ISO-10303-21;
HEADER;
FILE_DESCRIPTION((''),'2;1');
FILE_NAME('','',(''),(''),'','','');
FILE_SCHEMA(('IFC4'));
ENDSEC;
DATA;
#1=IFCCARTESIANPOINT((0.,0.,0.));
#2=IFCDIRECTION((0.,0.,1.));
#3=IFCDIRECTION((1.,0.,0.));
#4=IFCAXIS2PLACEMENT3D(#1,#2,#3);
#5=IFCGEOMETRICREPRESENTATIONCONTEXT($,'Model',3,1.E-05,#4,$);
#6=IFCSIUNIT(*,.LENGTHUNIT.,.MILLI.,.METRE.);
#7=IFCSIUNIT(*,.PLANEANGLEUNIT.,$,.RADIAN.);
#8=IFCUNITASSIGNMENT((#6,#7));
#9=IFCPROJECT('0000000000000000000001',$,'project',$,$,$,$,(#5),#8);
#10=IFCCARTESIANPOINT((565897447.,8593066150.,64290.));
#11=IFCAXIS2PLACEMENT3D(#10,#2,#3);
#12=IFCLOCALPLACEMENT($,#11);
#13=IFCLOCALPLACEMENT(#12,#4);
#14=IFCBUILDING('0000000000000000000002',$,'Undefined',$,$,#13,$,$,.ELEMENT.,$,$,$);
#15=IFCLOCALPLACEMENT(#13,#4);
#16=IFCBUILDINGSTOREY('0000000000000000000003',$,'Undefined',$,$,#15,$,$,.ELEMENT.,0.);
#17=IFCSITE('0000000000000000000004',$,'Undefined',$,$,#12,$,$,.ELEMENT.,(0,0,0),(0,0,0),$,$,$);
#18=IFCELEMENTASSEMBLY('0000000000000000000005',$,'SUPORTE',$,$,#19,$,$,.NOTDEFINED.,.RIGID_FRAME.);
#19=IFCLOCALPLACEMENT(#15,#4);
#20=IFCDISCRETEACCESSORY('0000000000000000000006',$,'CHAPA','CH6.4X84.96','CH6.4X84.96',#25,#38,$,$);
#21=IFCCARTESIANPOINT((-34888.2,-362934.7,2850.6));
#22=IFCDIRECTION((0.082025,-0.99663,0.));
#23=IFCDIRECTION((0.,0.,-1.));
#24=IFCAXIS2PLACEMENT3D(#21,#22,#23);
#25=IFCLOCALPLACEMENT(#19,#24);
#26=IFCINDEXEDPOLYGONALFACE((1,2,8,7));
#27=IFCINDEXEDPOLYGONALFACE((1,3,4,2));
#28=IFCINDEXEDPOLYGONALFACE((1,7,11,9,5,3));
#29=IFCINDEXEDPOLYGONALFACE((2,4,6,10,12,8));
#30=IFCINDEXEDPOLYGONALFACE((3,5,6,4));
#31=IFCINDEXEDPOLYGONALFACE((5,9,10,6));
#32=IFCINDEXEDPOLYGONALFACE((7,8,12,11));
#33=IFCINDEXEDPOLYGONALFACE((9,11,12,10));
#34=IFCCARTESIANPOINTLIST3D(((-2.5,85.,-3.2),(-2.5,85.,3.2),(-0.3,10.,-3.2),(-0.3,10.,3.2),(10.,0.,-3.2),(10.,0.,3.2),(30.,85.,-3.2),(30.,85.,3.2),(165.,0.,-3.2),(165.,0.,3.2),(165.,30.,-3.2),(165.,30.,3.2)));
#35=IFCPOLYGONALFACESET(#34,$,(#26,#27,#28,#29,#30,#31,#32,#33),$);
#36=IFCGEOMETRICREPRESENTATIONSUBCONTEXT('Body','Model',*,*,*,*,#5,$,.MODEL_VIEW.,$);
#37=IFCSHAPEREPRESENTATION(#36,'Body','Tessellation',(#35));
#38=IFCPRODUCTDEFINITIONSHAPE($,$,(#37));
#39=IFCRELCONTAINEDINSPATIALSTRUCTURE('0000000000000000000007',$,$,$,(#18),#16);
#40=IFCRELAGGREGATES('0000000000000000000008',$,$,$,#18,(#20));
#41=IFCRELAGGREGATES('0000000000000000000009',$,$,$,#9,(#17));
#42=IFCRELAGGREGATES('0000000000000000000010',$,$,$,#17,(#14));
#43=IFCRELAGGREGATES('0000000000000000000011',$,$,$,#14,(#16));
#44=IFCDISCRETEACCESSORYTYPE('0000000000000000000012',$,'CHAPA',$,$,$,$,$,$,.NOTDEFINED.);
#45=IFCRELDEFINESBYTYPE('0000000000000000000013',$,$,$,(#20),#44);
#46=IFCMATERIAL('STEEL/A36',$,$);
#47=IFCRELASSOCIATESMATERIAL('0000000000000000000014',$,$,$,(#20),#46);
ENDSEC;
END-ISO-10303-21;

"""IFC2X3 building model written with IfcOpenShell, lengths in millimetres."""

from ifc_helpers import new_model, si_unit, frame, origin_with_axes, place, context, subcontext, project, spatial, polyline, outline, extrude, material, type_object, element, aggregate, save


model = new_model("IFC2X3")

# Units and contexts
model_context = context("Model", 3, precision=1e-05, world=origin_with_axes())
body_context = subcontext(model_context, "Body", "Model", "MODEL_VIEW")
ifc_project = project(units=[si_unit("LENGTHUNIT", "METRE", prefix="MILLI"), si_unit("PLANEANGLEUNIT", "RADIAN")], contexts=[model_context])

# Site, building, storey
site_placement = place(None, frame((565897447.0, 8593066150.0, 64290.0), z_axis=(0.0, 0.0, 1.0), x_axis=(1.0, 0.0, 0.0)))
site = spatial("IfcSite", under=ifc_project, at=site_placement, Name="Undefined", CompositionType="ELEMENT", RefLatitude=(0, 0, 0), RefLongitude=(0, 0, 0))
building_placement = place(site_placement, origin_with_axes())
building = spatial("IfcBuilding", under=site, at=building_placement, Name="Undefined", CompositionType="ELEMENT")
storey_placement = place(building_placement, origin_with_axes())
storey = spatial("IfcBuildingStorey", under=building, at=storey_placement, Name="Undefined", CompositionType="ELEMENT", Elevation=0.0)

# Shared definitions
ifc_material_1 = material(Name="STEEL/A36")

# Shared definitions
discrete_accessory_type_1 = type_object("IfcDiscreteAccessoryType", Name="CHAPA")

# Element assembly, discrete accessory
assembly_1_placement = place(storey_placement, origin_with_axes())
assembly_1 = element("IfcElementAssembly", 1, at=assembly_1_placement, inside=storey, Name="SUPORTE", AssemblyPlace="NOTDEFINED", PredefinedType="RIGID_FRAME")
discrete_accessory_1_placement = place(assembly_1_placement, frame((-34888.2, -362934.7, 2850.6), z_axis=(0.082025, -0.99663, 0.0), x_axis=(0.0, 0.0, -1.0)))
discrete_accessory_1 = element("IfcDiscreteAccessory", 2, at=discrete_accessory_1_placement, type_object=discrete_accessory_type_1, material=ifc_material_1, Name="CHAPA", Description="CH6.4X84.96", ObjectType="CH6.4X84.96", context=body_context, shape_type="SweptSolid", body=[
    extrude(outline(polyline([(-0.3, 10.0), (10.0, 0.0), (165.0, 0.0), (165.0, 30.0), (30.0, 85.0), (-2.5, 85.0), (-0.3, 10.0)])), frame((0.0, 0.0, -3.2), z_axis=(0.0, 0.0, 1.0), x_axis=(1.0, 0.0, 0.0)), (0.0, 0.0, 1.0), 6.4),
])
aggregate(assembly_1, [discrete_accessory_1])

save(model, "model.ifc")
